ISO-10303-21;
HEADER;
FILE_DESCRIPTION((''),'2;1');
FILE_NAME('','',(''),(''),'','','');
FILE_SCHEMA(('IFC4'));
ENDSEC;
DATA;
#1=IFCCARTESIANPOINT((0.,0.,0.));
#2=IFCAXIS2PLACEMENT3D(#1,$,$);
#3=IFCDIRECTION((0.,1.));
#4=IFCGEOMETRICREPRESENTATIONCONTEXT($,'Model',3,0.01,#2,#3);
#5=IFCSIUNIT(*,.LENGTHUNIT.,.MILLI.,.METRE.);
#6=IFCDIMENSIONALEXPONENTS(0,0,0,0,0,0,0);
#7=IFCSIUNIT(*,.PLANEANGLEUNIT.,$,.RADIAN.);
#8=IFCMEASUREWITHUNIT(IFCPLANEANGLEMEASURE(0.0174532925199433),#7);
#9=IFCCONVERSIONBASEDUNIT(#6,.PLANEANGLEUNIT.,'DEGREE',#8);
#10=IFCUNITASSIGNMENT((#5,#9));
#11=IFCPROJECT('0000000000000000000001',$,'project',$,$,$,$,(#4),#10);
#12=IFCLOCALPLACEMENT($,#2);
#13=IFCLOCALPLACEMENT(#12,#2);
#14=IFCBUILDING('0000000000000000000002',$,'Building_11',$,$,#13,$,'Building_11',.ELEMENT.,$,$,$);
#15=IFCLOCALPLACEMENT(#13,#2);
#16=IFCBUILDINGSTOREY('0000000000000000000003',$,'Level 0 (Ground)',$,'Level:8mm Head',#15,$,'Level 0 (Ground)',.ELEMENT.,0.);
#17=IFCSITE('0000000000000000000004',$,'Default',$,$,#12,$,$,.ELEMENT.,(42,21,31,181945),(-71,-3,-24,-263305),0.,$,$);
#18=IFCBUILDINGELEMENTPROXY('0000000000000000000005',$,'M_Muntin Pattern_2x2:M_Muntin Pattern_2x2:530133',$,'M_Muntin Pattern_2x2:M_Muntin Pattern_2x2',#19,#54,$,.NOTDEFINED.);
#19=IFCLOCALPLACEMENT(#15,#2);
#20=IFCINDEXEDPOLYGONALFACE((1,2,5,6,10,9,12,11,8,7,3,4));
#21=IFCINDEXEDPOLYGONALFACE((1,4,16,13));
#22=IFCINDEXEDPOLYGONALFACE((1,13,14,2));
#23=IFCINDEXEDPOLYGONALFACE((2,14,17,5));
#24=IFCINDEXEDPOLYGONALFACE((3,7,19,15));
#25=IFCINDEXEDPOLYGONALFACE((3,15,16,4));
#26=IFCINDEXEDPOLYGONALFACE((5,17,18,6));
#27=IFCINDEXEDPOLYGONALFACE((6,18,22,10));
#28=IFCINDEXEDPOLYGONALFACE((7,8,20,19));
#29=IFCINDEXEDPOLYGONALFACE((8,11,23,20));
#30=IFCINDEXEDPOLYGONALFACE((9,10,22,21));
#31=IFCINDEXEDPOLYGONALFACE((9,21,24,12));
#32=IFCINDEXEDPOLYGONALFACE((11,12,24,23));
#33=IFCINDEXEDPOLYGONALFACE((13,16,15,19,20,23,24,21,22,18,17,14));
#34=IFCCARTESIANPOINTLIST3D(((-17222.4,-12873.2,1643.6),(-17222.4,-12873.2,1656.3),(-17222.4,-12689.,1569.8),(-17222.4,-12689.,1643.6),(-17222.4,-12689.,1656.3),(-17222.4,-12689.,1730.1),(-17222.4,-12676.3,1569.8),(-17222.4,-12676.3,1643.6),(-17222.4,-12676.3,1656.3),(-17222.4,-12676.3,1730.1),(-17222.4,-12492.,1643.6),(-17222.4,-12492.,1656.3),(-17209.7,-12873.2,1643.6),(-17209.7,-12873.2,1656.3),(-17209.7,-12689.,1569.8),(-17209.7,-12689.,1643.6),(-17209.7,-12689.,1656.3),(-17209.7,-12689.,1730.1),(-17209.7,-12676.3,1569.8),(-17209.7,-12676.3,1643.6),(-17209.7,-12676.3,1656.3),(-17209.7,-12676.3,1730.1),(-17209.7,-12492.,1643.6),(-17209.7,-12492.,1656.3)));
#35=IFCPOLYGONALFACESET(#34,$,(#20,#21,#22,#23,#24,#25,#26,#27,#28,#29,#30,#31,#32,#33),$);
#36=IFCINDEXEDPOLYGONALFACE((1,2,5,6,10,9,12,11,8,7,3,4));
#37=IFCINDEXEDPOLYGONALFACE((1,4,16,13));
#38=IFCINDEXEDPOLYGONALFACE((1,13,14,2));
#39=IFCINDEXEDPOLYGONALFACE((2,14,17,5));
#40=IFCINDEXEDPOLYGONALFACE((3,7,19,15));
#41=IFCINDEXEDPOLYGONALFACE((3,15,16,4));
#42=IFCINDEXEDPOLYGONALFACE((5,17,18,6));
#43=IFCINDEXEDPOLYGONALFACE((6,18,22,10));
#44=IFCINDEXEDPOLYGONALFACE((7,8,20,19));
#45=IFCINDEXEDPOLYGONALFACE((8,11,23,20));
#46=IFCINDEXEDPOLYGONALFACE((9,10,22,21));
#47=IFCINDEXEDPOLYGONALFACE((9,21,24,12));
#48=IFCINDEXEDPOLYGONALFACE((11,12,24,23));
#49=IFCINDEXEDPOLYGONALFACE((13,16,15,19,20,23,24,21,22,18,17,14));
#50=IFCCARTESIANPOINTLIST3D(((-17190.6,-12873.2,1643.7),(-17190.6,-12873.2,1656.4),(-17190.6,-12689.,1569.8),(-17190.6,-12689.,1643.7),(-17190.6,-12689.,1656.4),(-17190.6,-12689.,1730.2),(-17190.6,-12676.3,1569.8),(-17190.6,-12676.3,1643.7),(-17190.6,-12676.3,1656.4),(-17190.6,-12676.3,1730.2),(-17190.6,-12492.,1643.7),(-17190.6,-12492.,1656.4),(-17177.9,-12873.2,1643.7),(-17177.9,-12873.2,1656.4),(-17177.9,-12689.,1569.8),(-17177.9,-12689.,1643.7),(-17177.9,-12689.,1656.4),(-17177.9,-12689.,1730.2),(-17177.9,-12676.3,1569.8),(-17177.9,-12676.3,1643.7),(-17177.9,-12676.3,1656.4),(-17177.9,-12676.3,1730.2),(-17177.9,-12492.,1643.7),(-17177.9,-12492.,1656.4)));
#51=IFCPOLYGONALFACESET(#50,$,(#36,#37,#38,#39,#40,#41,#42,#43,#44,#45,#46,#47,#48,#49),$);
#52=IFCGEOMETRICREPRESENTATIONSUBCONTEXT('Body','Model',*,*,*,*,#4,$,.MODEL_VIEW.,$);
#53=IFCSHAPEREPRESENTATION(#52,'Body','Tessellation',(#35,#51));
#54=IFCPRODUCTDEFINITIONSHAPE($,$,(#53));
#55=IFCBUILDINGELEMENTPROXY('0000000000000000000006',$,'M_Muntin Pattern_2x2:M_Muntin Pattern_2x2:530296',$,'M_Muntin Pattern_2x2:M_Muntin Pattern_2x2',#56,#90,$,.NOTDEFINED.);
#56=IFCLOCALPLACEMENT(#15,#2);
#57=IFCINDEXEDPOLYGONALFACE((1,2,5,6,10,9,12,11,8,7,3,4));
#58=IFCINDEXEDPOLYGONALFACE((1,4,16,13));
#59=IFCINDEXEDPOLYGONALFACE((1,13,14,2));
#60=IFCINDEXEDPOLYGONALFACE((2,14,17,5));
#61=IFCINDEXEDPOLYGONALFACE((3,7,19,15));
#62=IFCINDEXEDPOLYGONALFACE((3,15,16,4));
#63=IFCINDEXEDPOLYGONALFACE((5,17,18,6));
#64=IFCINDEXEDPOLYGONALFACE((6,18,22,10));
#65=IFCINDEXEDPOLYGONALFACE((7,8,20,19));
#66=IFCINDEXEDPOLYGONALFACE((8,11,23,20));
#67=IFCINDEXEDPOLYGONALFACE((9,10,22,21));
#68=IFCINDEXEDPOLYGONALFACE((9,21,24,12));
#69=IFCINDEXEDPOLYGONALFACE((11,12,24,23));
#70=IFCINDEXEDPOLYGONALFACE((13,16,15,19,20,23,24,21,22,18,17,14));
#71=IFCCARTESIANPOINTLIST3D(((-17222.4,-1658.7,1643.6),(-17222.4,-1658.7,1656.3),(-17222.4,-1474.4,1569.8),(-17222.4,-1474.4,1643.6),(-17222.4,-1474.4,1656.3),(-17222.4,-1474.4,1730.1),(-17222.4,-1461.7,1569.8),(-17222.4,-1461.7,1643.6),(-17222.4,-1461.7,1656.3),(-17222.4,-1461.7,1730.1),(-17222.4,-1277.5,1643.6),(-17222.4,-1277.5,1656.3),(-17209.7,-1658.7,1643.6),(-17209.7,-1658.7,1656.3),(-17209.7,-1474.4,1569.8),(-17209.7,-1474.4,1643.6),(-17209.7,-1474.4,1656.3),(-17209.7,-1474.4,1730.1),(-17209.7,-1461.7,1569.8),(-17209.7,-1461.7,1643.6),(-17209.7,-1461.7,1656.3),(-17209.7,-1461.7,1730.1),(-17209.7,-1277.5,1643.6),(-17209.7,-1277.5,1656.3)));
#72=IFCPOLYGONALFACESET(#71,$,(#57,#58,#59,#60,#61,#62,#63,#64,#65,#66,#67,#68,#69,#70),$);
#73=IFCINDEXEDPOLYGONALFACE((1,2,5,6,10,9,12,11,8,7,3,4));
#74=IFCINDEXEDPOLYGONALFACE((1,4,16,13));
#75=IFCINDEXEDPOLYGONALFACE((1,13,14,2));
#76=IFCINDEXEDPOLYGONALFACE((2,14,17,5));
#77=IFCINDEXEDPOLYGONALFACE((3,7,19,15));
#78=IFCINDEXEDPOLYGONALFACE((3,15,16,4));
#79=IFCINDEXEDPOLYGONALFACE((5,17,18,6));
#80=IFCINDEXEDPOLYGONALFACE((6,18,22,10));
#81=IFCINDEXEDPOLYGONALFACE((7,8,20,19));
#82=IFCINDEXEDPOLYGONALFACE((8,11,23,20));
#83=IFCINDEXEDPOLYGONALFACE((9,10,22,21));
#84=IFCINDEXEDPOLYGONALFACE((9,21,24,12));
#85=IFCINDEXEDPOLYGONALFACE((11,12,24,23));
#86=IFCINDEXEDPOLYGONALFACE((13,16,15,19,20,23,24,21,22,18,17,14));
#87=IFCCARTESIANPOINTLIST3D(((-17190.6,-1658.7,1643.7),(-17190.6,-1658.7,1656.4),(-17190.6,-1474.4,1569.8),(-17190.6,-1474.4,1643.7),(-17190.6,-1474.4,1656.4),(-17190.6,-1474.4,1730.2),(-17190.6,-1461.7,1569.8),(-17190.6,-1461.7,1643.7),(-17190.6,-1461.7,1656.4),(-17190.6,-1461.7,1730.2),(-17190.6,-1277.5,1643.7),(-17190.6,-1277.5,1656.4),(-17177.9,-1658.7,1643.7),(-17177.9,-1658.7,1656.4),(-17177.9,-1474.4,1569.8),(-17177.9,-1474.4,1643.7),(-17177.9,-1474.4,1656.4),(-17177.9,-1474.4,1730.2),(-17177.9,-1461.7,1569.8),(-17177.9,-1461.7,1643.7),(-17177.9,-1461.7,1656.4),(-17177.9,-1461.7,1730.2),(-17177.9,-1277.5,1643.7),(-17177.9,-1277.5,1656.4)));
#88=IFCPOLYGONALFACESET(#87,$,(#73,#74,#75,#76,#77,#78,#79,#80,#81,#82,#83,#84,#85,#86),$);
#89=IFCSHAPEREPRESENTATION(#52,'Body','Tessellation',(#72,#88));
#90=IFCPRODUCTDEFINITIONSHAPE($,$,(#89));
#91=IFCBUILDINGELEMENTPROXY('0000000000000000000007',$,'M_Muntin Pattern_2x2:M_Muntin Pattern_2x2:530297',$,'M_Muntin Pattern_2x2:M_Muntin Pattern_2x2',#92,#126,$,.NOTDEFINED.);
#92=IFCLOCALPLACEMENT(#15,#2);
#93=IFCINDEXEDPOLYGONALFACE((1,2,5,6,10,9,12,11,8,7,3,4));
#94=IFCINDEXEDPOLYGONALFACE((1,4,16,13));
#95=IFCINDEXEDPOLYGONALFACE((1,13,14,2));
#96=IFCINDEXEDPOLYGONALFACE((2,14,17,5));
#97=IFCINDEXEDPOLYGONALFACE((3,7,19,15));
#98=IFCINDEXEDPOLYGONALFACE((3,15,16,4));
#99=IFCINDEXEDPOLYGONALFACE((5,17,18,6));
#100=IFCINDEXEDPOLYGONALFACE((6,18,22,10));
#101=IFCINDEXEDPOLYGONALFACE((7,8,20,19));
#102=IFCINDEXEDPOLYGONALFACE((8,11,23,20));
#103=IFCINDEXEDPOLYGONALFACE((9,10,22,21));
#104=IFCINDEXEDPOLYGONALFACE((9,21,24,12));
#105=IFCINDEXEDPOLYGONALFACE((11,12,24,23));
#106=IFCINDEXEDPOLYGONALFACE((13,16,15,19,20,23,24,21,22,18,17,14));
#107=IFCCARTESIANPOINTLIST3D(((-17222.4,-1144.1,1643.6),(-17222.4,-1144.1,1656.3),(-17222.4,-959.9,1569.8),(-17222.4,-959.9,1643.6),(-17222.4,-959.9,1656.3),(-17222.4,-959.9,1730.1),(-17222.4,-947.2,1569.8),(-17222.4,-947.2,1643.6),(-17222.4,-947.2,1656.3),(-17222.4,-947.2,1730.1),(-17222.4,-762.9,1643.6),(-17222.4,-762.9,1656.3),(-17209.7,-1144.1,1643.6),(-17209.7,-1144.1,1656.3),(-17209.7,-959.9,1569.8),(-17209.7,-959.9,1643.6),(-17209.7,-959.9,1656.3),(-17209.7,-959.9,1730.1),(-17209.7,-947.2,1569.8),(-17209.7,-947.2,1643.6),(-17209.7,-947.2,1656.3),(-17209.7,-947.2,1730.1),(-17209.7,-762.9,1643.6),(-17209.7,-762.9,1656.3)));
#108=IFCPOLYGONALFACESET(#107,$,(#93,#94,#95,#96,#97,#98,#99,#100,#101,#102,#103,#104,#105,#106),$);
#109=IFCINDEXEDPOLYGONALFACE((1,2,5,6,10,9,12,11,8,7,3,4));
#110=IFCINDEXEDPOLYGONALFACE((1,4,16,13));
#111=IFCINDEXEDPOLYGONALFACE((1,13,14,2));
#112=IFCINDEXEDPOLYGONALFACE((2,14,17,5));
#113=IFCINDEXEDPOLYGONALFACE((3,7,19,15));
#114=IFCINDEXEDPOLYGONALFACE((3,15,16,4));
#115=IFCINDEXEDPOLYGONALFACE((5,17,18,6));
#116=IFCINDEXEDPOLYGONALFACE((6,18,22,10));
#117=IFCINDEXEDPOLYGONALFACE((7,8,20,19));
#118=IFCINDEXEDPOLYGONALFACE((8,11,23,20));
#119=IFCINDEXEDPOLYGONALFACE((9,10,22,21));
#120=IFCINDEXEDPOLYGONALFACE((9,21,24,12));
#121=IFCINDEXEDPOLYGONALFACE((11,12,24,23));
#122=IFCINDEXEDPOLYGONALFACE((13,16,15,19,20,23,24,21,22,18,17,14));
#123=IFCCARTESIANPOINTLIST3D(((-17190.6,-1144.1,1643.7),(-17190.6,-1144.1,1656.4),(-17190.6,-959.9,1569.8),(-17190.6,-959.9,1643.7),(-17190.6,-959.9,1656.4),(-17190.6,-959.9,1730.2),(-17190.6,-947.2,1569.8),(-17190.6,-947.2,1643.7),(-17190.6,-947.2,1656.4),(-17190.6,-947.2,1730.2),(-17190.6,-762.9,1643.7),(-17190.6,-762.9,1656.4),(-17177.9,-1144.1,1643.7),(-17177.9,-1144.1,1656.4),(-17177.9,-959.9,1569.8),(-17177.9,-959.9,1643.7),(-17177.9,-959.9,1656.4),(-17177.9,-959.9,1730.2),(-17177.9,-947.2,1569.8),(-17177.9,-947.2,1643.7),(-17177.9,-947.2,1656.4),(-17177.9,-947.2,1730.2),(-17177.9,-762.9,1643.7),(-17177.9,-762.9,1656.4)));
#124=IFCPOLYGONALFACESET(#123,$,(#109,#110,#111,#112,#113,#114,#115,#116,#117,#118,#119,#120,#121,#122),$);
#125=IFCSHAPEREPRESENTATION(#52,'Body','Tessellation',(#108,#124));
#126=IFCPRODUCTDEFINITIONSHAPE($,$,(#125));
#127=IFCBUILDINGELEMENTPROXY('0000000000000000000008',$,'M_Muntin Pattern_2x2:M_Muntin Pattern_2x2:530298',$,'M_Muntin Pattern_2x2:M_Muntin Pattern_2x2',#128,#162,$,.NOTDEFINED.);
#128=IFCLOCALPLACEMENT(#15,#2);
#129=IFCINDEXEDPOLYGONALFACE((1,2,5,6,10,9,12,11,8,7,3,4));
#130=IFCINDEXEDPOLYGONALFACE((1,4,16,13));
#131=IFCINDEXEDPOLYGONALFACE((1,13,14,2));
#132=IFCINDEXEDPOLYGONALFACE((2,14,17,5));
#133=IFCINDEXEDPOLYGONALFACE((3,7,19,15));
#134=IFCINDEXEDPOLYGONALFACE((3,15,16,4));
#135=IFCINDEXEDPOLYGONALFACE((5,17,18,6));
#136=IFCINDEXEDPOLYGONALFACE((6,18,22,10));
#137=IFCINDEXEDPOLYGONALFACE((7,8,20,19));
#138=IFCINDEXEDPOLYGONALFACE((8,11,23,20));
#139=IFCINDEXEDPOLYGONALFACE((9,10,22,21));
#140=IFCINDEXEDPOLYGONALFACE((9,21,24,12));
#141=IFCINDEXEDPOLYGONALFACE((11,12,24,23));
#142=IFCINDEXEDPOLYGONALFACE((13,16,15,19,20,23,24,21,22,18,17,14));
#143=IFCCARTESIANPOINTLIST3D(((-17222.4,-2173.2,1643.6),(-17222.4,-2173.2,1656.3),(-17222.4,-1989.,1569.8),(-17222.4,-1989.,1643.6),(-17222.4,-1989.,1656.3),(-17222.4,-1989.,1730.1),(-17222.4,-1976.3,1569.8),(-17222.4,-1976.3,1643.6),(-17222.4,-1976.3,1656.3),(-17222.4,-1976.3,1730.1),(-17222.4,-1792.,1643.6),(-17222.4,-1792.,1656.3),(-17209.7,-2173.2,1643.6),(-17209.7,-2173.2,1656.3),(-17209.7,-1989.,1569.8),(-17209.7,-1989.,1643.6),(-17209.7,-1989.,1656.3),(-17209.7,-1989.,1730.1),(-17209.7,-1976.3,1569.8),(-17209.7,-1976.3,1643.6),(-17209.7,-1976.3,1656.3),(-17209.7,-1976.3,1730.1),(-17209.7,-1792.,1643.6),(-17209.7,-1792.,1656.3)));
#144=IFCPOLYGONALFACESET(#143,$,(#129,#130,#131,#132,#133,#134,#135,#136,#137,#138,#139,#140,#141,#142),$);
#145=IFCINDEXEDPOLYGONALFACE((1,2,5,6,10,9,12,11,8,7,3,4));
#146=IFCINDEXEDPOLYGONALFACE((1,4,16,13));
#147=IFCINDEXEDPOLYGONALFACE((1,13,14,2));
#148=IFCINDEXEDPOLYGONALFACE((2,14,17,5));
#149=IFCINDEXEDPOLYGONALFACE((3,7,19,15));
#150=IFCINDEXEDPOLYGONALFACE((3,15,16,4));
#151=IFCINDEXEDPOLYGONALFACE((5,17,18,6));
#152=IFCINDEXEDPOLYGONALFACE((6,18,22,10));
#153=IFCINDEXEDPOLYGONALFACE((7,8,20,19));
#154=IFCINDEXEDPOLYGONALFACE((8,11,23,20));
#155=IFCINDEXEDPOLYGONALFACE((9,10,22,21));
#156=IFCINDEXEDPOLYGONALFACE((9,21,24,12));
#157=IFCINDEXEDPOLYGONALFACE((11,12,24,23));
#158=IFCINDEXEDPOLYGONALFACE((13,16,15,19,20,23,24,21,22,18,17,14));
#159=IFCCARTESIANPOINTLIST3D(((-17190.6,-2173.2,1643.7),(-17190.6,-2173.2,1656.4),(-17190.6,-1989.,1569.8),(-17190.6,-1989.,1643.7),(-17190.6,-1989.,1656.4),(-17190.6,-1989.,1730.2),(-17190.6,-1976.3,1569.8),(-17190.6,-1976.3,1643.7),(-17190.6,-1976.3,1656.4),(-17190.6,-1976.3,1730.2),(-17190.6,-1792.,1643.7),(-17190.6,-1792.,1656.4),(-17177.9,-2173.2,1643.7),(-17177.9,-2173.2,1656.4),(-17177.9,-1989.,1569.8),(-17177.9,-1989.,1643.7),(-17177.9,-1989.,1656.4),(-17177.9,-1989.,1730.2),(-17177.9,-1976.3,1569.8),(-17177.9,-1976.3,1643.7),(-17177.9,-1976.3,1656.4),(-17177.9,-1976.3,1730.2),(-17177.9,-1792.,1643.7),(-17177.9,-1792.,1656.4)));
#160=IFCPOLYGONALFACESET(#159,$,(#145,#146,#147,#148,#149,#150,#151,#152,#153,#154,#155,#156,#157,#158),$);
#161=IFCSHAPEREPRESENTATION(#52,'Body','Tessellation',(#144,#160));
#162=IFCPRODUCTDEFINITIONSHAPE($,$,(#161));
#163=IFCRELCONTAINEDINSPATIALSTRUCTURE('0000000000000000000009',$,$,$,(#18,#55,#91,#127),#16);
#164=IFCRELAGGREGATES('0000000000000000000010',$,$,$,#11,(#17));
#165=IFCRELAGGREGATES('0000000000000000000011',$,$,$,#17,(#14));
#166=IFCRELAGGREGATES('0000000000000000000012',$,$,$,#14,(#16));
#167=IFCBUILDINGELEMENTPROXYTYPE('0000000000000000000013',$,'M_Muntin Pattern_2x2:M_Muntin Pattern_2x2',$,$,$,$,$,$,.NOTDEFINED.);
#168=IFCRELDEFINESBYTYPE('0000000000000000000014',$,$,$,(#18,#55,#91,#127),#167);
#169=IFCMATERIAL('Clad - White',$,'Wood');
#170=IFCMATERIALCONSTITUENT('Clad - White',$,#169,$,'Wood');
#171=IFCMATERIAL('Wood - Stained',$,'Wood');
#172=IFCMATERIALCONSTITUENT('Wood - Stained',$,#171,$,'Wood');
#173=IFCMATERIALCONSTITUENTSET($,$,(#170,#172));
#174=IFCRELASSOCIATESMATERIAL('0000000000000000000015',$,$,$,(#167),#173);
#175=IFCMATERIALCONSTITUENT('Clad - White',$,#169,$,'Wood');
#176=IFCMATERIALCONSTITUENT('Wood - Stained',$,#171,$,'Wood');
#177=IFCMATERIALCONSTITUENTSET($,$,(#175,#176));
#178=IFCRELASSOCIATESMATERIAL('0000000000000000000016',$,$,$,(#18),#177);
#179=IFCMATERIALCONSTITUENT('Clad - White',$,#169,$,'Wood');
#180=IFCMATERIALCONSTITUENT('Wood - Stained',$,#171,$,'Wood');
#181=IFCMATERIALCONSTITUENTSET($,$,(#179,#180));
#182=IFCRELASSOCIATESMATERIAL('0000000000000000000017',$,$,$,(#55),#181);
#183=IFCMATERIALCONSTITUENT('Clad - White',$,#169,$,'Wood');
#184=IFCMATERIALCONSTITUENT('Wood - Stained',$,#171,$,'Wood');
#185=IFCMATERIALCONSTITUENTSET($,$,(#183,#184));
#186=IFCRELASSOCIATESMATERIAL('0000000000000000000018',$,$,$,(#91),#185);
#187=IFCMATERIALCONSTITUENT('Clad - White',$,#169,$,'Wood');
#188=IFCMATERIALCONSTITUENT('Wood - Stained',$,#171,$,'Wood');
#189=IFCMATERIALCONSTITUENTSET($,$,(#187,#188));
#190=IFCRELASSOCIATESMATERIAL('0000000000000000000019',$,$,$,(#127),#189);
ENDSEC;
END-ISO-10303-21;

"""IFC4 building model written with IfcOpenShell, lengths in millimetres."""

from ifc_helpers import new_model, entity, si_unit, converted_unit, direction, frame, origin, place, context, subcontext, project, spatial, indexed_curve, outline, extrude, source, transform, mapped, material, constituent, constituent_set, type_object, type_shapes, element, save


model = new_model("IFC4")

# Units and contexts
model_context = context("Model", 3, precision=0.01, world=origin(), true_north=direction((0.0, 1.0)))
body_context = subcontext(model_context, "Body", "Model", "MODEL_VIEW")
ifc_project = project(units=[si_unit("LENGTHUNIT", "METRE", prefix="MILLI"), converted_unit("PLANEANGLEUNIT", "DEGREE", entity("IfcPlaneAngleMeasure", 0.0174532925199433), si_unit("PLANEANGLEUNIT", "RADIAN"), dimensions=[0, 0, 0, 0, 0, 0, 0])], contexts=[model_context])

# Site, building, storey
site_placement = place(None, origin())
site = spatial("IfcSite", under=ifc_project, at=site_placement, Name="Default", CompositionType="ELEMENT", RefLatitude=(42, 21, 31, 181945), RefLongitude=(-71, -3, -24, -263305), RefElevation=0.0)
building_placement = place(site_placement, origin())
building = spatial("IfcBuilding", under=site, at=building_placement, Name="Building_11", LongName="Building_11", CompositionType="ELEMENT")
storey_placement = place(building_placement, origin())
storey = spatial("IfcBuildingStorey", under=building, at=storey_placement, Name="Level 0 (Ground)", ObjectType="Level:8mm Head", LongName="Level 0 (Ground)", CompositionType="ELEMENT", Elevation=0.0)

# Building element proxies
ifc_material_1 = material(Name="Clad - White", Category="Wood")
ifc_material_2 = material(Name="Wood - Stained", Category="Wood")
ifc_constituent_1 = constituent(ifc_material_1, Name="Clad - White", Category="Wood")
ifc_constituent_2 = constituent(ifc_material_2, Name="Wood - Stained", Category="Wood")
ifc_constituent_set_1 = constituent_set(constituents=[ifc_constituent_1, ifc_constituent_2])
building_element_proxy_type_1 = type_object("IfcBuildingElementProxyType", Name="M_Muntin Pattern_2x2:M_Muntin Pattern_2x2", PredefinedType="NOTDEFINED", material=ifc_constituent_set_1)
shared_shape_1 = source(origin(), body_context, "Body", "SweptSolid", [
    extrude(outline(indexed_curve([(6.4, -6.4), (80.1, -6.4), (80.1, 6.3), (6.4, 6.3), (6.4, 190.6), (-6.3, 190.6), (-6.3, 6.3), (-80.2, 6.3), (-80.2, -6.4), (-6.3, -6.4), (-6.3, -190.6), (6.4, -190.6), (6.4, -6.4)], self_intersect=False)), frame((0.0, 9.5, 80.1), z_axis=(0.0, 1.0, 0.0), x_axis=(0.0, 0.0, 1.0)), (0.0, 0.0, 1.0), 12.7),
    extrude(outline(indexed_curve([(6.4, -6.4), (80.2, -6.4), (80.2, 6.3), (6.4, 6.3), (6.4, 190.6), (-6.3, 190.6), (-6.3, 6.3), (-80.2, 6.3), (-80.2, -6.4), (-6.3, -6.4), (-6.3, -190.6), (6.4, -190.6), (6.4, -6.4)], self_intersect=False)), frame((0.0, -22.2, 80.2), z_axis=(0.0, 1.0, 0.0), x_axis=(0.0, 0.0, 1.0)), (0.0, 0.0, 1.0), 12.7),
])
type_shapes(building_element_proxy_type_1, [shared_shape_1])
ifc_constituent_3 = constituent(ifc_material_1, Name="Clad - White", Category="Wood")
ifc_constituent_4 = constituent(ifc_material_2, Name="Wood - Stained", Category="Wood")
ifc_constituent_set_2 = constituent_set(constituents=[ifc_constituent_3, ifc_constituent_4])
proxy_1_placement = place(storey_placement, frame((-17200.2, -12682.6, 1569.8), z_axis=(0.0, 0.0, 1.0), x_axis=(0.0, 1.0, 0.0)))
element("IfcBuildingElementProxy", 1, at=proxy_1_placement, inside=storey, type_object=building_element_proxy_type_1, material=ifc_constituent_set_2, Name="M_Muntin Pattern_2x2:M_Muntin Pattern_2x2:530133", ObjectType="M_Muntin Pattern_2x2:M_Muntin Pattern_2x2", PredefinedType="NOTDEFINED", context=body_context, shape_type="MappedRepresentation", body=[
    mapped(shared_shape_1, transform((0.0, 0.0, 0.0), scale=1.0)),
])
ifc_constituent_5 = constituent(ifc_material_1, Name="Clad - White", Category="Wood")
ifc_constituent_6 = constituent(ifc_material_2, Name="Wood - Stained", Category="Wood")
ifc_constituent_set_3 = constituent_set(constituents=[ifc_constituent_5, ifc_constituent_6])
proxy_2_placement = place(storey_placement, frame((-17200.2, -1468.1, 1569.8), z_axis=(0.0, 0.0, 1.0), x_axis=(0.0, 1.0, 0.0)))
element("IfcBuildingElementProxy", 2, at=proxy_2_placement, inside=storey, type_object=building_element_proxy_type_1, material=ifc_constituent_set_3, Name="M_Muntin Pattern_2x2:M_Muntin Pattern_2x2:530296", ObjectType="M_Muntin Pattern_2x2:M_Muntin Pattern_2x2", PredefinedType="NOTDEFINED", context=body_context, shape_type="MappedRepresentation", body=[
    mapped(shared_shape_1, transform((0.0, 0.0, 0.0), scale=1.0)),
])
ifc_constituent_7 = constituent(ifc_material_1, Name="Clad - White", Category="Wood")
ifc_constituent_8 = constituent(ifc_material_2, Name="Wood - Stained", Category="Wood")
ifc_constituent_set_4 = constituent_set(constituents=[ifc_constituent_7, ifc_constituent_8])
proxy_3_placement = place(storey_placement, frame((-17200.2, -953.5, 1569.8), z_axis=(0.0, 0.0, 1.0), x_axis=(0.0, 1.0, 0.0)))
element("IfcBuildingElementProxy", 3, at=proxy_3_placement, inside=storey, type_object=building_element_proxy_type_1, material=ifc_constituent_set_4, Name="M_Muntin Pattern_2x2:M_Muntin Pattern_2x2:530297", ObjectType="M_Muntin Pattern_2x2:M_Muntin Pattern_2x2", PredefinedType="NOTDEFINED", context=body_context, shape_type="MappedRepresentation", body=[
    mapped(shared_shape_1, transform((0.0, 0.0, 0.0), scale=1.0)),
])
ifc_constituent_9 = constituent(ifc_material_1, Name="Clad - White", Category="Wood")
ifc_constituent_10 = constituent(ifc_material_2, Name="Wood - Stained", Category="Wood")
ifc_constituent_set_5 = constituent_set(constituents=[ifc_constituent_9, ifc_constituent_10])
proxy_4_placement = place(storey_placement, frame((-17200.2, -1982.6, 1569.8), z_axis=(0.0, 0.0, 1.0), x_axis=(0.0, 1.0, 0.0)))
element("IfcBuildingElementProxy", 4, at=proxy_4_placement, inside=storey, type_object=building_element_proxy_type_1, material=ifc_constituent_set_5, Name="M_Muntin Pattern_2x2:M_Muntin Pattern_2x2:530298", ObjectType="M_Muntin Pattern_2x2:M_Muntin Pattern_2x2", PredefinedType="NOTDEFINED", context=body_context, shape_type="MappedRepresentation", body=[
    mapped(shared_shape_1, transform((0.0, 0.0, 0.0), scale=1.0)),
])

save(model, "model.ifc")
